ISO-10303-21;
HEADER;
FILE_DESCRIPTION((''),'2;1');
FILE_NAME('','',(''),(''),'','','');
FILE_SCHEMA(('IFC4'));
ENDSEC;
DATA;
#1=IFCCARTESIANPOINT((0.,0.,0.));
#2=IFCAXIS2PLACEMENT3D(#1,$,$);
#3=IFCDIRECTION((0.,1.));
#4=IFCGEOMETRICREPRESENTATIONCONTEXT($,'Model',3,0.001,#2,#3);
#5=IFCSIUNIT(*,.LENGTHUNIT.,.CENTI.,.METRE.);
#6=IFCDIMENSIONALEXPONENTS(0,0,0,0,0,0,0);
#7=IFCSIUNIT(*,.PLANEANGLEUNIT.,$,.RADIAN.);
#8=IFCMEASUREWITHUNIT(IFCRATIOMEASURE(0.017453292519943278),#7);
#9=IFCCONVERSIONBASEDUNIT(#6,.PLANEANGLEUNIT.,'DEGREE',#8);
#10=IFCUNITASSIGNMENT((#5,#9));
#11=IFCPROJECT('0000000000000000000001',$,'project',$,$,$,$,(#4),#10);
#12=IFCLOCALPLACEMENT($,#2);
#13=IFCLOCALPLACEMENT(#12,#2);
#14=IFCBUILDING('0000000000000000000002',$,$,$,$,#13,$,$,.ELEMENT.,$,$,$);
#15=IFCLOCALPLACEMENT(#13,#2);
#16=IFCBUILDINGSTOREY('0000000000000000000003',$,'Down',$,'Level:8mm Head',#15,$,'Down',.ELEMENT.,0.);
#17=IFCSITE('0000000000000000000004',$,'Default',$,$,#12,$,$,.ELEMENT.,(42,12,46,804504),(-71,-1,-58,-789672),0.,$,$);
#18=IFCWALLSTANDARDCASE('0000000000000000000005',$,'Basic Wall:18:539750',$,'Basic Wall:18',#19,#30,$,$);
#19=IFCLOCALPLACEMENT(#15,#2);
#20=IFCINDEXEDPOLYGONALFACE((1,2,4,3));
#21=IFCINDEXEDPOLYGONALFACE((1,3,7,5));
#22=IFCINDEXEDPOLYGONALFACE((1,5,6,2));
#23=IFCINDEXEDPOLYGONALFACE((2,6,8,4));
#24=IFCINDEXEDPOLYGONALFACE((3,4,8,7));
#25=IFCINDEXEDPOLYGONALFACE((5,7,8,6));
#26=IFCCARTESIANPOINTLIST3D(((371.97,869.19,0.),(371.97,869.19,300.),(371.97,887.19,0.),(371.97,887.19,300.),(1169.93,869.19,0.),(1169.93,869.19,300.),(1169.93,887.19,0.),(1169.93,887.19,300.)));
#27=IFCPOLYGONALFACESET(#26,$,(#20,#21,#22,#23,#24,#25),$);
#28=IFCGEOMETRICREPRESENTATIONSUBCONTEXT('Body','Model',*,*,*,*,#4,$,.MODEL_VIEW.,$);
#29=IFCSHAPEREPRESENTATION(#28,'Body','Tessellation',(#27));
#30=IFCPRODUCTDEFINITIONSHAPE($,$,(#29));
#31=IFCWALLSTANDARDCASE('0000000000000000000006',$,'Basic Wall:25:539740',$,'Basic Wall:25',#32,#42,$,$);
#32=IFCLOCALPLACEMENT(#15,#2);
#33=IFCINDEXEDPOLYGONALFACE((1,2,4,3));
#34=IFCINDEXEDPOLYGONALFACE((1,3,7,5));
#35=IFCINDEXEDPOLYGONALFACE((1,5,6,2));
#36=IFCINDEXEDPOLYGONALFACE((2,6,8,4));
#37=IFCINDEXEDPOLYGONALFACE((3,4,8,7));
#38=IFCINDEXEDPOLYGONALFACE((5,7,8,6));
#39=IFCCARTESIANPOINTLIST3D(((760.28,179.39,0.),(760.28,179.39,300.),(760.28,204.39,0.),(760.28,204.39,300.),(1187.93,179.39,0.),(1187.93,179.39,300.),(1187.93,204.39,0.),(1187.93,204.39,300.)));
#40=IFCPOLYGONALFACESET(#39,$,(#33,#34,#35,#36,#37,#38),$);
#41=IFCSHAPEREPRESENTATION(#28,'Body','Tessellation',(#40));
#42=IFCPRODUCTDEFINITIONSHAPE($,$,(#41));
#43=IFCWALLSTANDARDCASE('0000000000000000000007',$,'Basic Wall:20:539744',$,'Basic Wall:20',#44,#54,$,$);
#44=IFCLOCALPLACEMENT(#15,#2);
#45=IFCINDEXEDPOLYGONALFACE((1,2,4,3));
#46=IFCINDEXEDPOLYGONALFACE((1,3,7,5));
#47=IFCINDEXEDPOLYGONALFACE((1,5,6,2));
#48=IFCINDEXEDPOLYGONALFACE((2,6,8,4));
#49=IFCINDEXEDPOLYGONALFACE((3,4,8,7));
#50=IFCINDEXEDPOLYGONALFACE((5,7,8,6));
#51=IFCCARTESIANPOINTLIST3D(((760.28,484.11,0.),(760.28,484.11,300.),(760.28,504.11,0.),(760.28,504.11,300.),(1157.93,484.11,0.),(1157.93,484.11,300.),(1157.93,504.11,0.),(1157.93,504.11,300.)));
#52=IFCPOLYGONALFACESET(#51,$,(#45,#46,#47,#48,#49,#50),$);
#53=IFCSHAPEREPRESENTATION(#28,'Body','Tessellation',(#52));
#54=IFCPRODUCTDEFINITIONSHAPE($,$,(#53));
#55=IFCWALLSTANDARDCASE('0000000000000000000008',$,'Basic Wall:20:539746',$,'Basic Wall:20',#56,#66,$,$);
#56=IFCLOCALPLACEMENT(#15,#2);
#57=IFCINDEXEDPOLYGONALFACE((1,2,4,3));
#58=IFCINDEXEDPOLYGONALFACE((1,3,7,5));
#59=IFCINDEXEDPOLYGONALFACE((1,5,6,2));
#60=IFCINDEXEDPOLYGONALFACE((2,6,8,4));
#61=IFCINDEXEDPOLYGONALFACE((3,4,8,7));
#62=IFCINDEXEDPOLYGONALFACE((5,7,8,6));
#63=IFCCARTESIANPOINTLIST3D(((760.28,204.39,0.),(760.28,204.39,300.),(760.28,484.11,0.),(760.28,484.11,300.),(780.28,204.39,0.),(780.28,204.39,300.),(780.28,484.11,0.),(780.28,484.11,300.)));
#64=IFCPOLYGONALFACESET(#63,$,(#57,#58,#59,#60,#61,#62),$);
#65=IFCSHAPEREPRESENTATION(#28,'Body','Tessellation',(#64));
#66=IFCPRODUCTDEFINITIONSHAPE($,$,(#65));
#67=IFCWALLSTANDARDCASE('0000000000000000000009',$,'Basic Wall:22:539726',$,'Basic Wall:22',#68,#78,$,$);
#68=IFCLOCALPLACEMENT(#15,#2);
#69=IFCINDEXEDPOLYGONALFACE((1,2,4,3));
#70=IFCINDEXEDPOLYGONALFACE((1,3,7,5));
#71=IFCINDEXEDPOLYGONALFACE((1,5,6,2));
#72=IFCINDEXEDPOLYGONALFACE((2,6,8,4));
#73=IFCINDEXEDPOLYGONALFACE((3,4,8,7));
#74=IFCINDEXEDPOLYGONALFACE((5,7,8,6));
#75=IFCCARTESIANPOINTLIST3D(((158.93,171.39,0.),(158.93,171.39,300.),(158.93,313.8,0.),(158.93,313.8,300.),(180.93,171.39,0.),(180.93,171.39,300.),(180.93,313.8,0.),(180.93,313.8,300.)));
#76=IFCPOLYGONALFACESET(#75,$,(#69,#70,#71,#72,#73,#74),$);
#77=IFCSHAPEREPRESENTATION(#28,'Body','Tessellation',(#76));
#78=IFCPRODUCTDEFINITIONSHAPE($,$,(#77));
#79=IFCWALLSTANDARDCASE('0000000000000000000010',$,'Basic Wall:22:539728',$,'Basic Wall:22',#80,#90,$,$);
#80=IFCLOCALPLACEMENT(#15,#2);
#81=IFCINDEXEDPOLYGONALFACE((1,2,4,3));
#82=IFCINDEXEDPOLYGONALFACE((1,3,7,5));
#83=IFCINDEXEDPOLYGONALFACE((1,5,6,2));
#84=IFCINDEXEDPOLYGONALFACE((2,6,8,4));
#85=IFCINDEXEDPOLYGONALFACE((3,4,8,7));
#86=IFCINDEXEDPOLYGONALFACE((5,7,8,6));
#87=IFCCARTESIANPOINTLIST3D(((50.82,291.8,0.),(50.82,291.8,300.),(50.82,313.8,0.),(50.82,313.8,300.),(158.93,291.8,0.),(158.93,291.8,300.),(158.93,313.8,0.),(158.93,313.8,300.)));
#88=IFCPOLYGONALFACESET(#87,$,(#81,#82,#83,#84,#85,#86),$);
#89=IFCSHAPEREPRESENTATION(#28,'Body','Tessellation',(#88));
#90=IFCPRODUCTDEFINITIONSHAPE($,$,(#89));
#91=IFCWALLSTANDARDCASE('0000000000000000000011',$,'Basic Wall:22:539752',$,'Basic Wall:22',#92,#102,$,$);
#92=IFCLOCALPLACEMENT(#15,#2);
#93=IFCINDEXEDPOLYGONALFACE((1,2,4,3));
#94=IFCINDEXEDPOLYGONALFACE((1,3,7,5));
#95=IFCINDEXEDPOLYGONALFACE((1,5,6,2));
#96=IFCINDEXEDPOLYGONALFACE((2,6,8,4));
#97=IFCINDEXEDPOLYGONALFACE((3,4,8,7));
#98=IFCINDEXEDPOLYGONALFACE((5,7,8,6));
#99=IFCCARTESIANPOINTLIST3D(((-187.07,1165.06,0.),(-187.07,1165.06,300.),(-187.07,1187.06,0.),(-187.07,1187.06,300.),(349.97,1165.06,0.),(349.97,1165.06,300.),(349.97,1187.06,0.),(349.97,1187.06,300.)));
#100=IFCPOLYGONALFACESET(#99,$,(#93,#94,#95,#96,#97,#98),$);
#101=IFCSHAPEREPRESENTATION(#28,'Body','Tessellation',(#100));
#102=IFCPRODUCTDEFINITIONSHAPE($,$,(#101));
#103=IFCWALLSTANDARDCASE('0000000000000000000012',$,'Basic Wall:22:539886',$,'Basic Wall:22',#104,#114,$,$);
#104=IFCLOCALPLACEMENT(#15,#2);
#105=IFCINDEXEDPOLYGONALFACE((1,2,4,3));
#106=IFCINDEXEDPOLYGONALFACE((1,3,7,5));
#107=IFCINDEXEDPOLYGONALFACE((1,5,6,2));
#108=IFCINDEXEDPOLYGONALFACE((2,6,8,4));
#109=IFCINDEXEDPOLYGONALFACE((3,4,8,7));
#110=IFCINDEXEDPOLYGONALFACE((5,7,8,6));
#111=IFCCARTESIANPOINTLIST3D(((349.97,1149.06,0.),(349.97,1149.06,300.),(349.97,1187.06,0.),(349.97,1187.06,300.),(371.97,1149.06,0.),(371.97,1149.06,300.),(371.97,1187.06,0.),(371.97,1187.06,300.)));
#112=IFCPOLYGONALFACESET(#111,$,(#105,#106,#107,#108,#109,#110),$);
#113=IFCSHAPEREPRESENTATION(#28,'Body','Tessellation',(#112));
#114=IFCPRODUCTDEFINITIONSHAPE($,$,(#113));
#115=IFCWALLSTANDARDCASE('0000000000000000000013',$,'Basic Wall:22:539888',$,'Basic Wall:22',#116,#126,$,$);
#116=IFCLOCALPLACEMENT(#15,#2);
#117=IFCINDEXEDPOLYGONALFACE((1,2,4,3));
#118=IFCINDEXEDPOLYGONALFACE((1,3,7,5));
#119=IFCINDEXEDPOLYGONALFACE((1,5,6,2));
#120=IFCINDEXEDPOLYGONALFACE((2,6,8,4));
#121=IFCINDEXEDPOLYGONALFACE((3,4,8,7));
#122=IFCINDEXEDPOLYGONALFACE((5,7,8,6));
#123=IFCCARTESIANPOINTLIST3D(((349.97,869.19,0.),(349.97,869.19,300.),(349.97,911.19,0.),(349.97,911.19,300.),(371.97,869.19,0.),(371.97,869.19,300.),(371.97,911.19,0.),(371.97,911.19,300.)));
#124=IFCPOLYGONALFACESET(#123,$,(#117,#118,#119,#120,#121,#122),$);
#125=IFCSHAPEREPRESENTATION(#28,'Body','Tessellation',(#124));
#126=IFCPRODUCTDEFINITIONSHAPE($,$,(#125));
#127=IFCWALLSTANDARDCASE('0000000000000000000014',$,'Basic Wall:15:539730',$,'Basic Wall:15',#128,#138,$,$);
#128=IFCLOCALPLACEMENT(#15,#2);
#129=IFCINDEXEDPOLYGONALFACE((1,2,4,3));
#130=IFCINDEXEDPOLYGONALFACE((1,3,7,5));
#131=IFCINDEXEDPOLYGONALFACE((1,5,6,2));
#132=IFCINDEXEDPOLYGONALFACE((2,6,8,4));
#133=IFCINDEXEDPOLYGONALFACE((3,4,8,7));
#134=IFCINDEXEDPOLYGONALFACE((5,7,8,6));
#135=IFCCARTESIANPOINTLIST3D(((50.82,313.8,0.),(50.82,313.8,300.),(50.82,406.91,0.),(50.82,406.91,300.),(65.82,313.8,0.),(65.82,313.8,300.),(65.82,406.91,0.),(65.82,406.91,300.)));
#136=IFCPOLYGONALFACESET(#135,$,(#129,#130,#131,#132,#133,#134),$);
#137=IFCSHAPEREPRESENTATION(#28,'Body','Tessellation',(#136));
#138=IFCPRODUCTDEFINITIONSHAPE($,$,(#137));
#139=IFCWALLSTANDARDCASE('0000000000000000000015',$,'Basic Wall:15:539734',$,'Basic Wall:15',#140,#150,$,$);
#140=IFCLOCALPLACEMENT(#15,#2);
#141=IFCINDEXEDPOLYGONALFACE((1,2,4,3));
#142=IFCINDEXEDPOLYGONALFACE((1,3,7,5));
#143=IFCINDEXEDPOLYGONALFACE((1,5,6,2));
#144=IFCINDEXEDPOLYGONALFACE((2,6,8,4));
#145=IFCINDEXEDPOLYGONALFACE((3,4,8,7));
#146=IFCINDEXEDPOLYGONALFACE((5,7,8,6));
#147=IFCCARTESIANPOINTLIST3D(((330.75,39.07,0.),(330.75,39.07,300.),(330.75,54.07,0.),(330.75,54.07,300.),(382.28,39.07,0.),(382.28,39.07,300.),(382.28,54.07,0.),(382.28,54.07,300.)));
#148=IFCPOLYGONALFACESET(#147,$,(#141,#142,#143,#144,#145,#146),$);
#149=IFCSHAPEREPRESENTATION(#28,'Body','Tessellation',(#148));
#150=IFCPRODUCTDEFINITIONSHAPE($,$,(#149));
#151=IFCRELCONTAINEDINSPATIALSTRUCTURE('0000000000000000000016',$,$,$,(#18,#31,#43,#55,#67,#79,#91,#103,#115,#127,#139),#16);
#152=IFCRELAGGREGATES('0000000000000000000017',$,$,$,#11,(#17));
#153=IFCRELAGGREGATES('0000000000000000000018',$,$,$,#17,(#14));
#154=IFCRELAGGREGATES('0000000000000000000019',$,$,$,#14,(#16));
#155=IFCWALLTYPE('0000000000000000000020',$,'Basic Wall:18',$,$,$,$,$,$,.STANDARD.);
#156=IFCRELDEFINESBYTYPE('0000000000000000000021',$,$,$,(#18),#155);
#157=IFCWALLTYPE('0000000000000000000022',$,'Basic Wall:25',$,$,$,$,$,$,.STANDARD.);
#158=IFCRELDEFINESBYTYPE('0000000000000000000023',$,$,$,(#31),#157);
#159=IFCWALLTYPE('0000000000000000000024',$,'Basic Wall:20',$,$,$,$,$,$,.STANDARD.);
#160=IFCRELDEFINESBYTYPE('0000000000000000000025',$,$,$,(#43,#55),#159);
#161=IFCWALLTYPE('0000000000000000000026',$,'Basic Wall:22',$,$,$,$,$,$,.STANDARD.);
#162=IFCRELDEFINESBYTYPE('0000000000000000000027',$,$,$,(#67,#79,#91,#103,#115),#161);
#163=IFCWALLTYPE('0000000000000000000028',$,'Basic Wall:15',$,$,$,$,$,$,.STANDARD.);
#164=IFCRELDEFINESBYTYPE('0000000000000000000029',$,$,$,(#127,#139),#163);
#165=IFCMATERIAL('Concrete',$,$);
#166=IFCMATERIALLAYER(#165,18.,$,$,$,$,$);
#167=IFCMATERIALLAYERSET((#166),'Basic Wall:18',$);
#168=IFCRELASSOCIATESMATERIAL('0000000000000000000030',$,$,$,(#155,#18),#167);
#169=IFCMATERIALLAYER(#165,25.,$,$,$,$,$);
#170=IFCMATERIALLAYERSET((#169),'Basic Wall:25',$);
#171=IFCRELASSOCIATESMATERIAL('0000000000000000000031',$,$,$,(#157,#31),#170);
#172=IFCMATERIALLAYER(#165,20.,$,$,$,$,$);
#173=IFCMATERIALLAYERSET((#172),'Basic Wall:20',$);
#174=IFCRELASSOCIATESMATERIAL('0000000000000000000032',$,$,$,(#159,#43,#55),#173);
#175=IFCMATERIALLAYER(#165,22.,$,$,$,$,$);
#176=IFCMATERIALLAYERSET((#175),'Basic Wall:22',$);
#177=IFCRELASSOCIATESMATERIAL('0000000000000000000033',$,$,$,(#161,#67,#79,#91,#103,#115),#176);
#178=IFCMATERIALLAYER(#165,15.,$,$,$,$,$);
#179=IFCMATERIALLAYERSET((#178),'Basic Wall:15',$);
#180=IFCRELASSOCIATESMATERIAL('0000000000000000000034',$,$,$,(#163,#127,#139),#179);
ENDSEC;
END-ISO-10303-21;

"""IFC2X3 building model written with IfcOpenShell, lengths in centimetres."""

from ifc_helpers import new_model, entity, si_unit, converted_unit, direction, frame, frame_2d, origin, place, context, subcontext, project, spatial, rectangle, extrude, material, layer, layer_set, layer_usage, type_object, element, save


model = new_model("IFC2X3")

# Units and contexts
model_context = context("Model", 3, precision=0.001, world=origin(), true_north=direction((0.0, 1.0)))
body_context = subcontext(model_context, "Body", "Model", "MODEL_VIEW")
ifc_project = project(units=[si_unit("LENGTHUNIT", "METRE", prefix="CENTI"), converted_unit("PLANEANGLEUNIT", "DEGREE", entity("IfcRatioMeasure", 0.017453292519943278), si_unit("PLANEANGLEUNIT", "RADIAN"), dimensions=[0, 0, 0, 0, 0, 0, 0])], contexts=[model_context])

# Site, building, storey
site_placement = place(None, origin())
site = spatial("IfcSite", under=ifc_project, at=site_placement, Name="Default", CompositionType="ELEMENT", RefLatitude=(42, 12, 46, 804504), RefLongitude=(-71, -1, -58, -789672), RefElevation=0.0)
building_placement = place(site_placement, origin())
building = spatial("IfcBuilding", under=site, at=building_placement, CompositionType="ELEMENT")
storey_placement = place(building_placement, origin())
storey = spatial("IfcBuildingStorey", under=building, at=storey_placement, Name="Down", ObjectType="Level:8mm Head", LongName="Down", CompositionType="ELEMENT", Elevation=0.0)

# Shared definitions
ifc_material = material(Name="Concrete")

# Walls
ifc_layer_1 = layer(ifc_material, 18.0)
ifc_layer_set_1 = layer_set([ifc_layer_1], Name="Basic Wall:18")
wall_type_1 = type_object("IfcWallType", Name="Basic Wall:18", PredefinedType="STANDARD", material=ifc_layer_set_1)
ifc_layer_usage_1 = layer_usage(ifc_layer_set_1, "AXIS2", "NEGATIVE", 9.0)
wall_1_placement = place(storey_placement, frame((1169.93, 878.19, 0.0), z_axis=(0.0, 0.0, 1.0), x_axis=(-1.0, 0.0, 0.0)))
element("IfcWallStandardCase", 1, at=wall_1_placement, inside=storey, type_object=wall_type_1, material=ifc_layer_usage_1, Name="Basic Wall:18:539750", ObjectType="Basic Wall:18", context=body_context, shape_type="SweptSolid", body=[
    extrude(rectangle(XDim=797.96, YDim=18.0, at=frame_2d((398.98, 0.0), x_axis=(-1.0, 0.0))), origin(), (0.0, 0.0, 1.0), 300.0),
])
ifc_layer_2 = layer(ifc_material, 25.0)
ifc_layer_set_2 = layer_set([ifc_layer_2], Name="Basic Wall:25")
ifc_layer_usage_2 = layer_usage(ifc_layer_set_2, "AXIS2", "POSITIVE", -12.5)
wall_type_2 = type_object("IfcWallType", Name="Basic Wall:25", PredefinedType="STANDARD", material=ifc_layer_set_2)
wall_2_placement = place(storey_placement, frame((1187.93, 191.89, 0.0), z_axis=(0.0, 0.0, 1.0), x_axis=(-1.0, 0.0, 0.0)))
element("IfcWallStandardCase", 2, at=wall_2_placement, inside=storey, type_object=wall_type_2, material=ifc_layer_usage_2, Name="Basic Wall:25:539740", ObjectType="Basic Wall:25", context=body_context, shape_type="SweptSolid", body=[
    extrude(rectangle(XDim=427.65, YDim=25.0, at=frame_2d((213.82, 0.0), x_axis=(-1.0, 0.0))), origin(), (0.0, 0.0, 1.0), 300.0),
])
ifc_layer_3 = layer(ifc_material, 20.0)
ifc_layer_set_3 = layer_set([ifc_layer_3], Name="Basic Wall:20")
ifc_layer_usage_3 = layer_usage(ifc_layer_set_3, "AXIS2", "POSITIVE", -10.0)
wall_type_3 = type_object("IfcWallType", Name="Basic Wall:20", PredefinedType="STANDARD", material=ifc_layer_set_3)
wall_3_placement = place(storey_placement, frame((1157.93, 494.11, 0.0), z_axis=(0.0, 0.0, 1.0), x_axis=(-1.0, 0.0, 0.0)))
element("IfcWallStandardCase", 3, at=wall_3_placement, inside=storey, type_object=wall_type_3, material=ifc_layer_usage_3, Name="Basic Wall:20:539744", ObjectType="Basic Wall:20", context=body_context, shape_type="SweptSolid", body=[
    extrude(rectangle(XDim=397.65, YDim=20.0, at=frame_2d((198.82, 0.0), x_axis=(-1.0, 0.0))), origin(), (0.0, 0.0, 1.0), 300.0),
])
ifc_layer_usage_4 = layer_usage(ifc_layer_set_3, "AXIS2", "POSITIVE", -10.0)
wall_4_placement = place(storey_placement, frame((770.28, 204.39, 0.0), z_axis=(0.0, 0.0, 1.0), x_axis=(0.0, 1.0, 0.0)))
element("IfcWallStandardCase", 4, at=wall_4_placement, inside=storey, type_object=wall_type_3, material=ifc_layer_usage_4, Name="Basic Wall:20:539746", ObjectType="Basic Wall:20", context=body_context, shape_type="SweptSolid", body=[
    extrude(rectangle(XDim=279.72, YDim=20.0, at=frame_2d((139.86, 0.0), x_axis=(-1.0, 0.0))), origin(), (0.0, 0.0, 1.0), 300.0),
])
ifc_layer_4 = layer(ifc_material, 22.0)
ifc_layer_set_4 = layer_set([ifc_layer_4], Name="Basic Wall:22")
ifc_layer_usage_5 = layer_usage(ifc_layer_set_4, "AXIS2", "POSITIVE", -11.0)
wall_type_4 = type_object("IfcWallType", Name="Basic Wall:22", PredefinedType="STANDARD", material=ifc_layer_set_4)
wall_5_placement = place(storey_placement, frame((169.93, 313.8, 0.0), z_axis=(0.0, 0.0, 1.0), x_axis=(0.0, -1.0, 0.0)))
element("IfcWallStandardCase", 5, at=wall_5_placement, inside=storey, type_object=wall_type_4, material=ifc_layer_usage_5, Name="Basic Wall:22:539726", ObjectType="Basic Wall:22", context=body_context, shape_type="SweptSolid", body=[
    extrude(rectangle(XDim=142.4, YDim=22.0, at=frame_2d((71.2, 0.0), x_axis=(-1.0, 0.0))), origin(), (0.0, 0.0, 1.0), 300.0),
])
ifc_layer_usage_6 = layer_usage(ifc_layer_set_4, "AXIS2", "NEGATIVE", 11.0)
wall_6_placement = place(storey_placement, frame((158.93, 302.8, 0.0), z_axis=(0.0, 0.0, 1.0), x_axis=(-1.0, 0.0, 0.0)))
element("IfcWallStandardCase", 6, at=wall_6_placement, inside=storey, type_object=wall_type_4, material=ifc_layer_usage_6, Name="Basic Wall:22:539728", ObjectType="Basic Wall:22", context=body_context, shape_type="SweptSolid", body=[
    extrude(rectangle(XDim=108.11, YDim=22.0, at=frame_2d((54.06, 0.0), x_axis=(-1.0, 0.0))), origin(), (0.0, 0.0, 1.0), 300.0),
])
ifc_layer_usage_7 = layer_usage(ifc_layer_set_4, "AXIS2", "NEGATIVE", 11.0)
wall_7_placement = place(storey_placement, frame((349.97, 1176.06, 0.0), z_axis=(0.0, 0.0, 1.0), x_axis=(-1.0, 0.0, 0.0)))
element("IfcWallStandardCase", 7, at=wall_7_placement, inside=storey, type_object=wall_type_4, material=ifc_layer_usage_7, Name="Basic Wall:22:539752", ObjectType="Basic Wall:22", context=body_context, shape_type="SweptSolid", body=[
    extrude(rectangle(XDim=537.04, YDim=22.0, at=frame_2d((268.52, 0.0), x_axis=(-1.0, 0.0))), origin(), (0.0, 0.0, 1.0), 300.0),
])
ifc_layer_usage_8 = layer_usage(ifc_layer_set_4, "AXIS2", "POSITIVE", -11.0)
wall_8_placement = place(storey_placement, frame((360.97, 1187.06, 0.0), z_axis=(0.0, 0.0, 1.0), x_axis=(0.0, -1.0, 0.0)))
element("IfcWallStandardCase", 8, at=wall_8_placement, inside=storey, type_object=wall_type_4, material=ifc_layer_usage_8, Name="Basic Wall:22:539886", ObjectType="Basic Wall:22", context=body_context, shape_type="SweptSolid", body=[
    extrude(rectangle(XDim=38.0, YDim=22.0, at=frame_2d((19.0, 0.0), x_axis=(-1.0, 0.0))), origin(), (0.0, 0.0, 1.0), 300.0),
])
ifc_layer_usage_9 = layer_usage(ifc_layer_set_4, "AXIS2", "POSITIVE", -11.0)
wall_9_placement = place(storey_placement, frame((360.97, 869.19, 0.0), z_axis=(0.0, 0.0, 1.0), x_axis=(0.0, 1.0, 0.0)))
element("IfcWallStandardCase", 9, at=wall_9_placement, inside=storey, type_object=wall_type_4, material=ifc_layer_usage_9, Name="Basic Wall:22:539888", ObjectType="Basic Wall:22", context=body_context, shape_type="SweptSolid", body=[
    extrude(rectangle(XDim=42.0, YDim=22.0, at=frame_2d((21.0, 0.0), x_axis=(-1.0, 0.0))), origin(), (0.0, 0.0, 1.0), 300.0),
])
ifc_layer_5 = layer(ifc_material, 15.0)
ifc_layer_set_5 = layer_set([ifc_layer_5], Name="Basic Wall:15")
ifc_layer_usage_10 = layer_usage(ifc_layer_set_5, "AXIS2", "NEGATIVE", 7.5)
wall_type_5 = type_object("IfcWallType", Name="Basic Wall:15", PredefinedType="STANDARD", material=ifc_layer_set_5)
wall_10_placement = place(storey_placement, frame((58.32, 406.91, 0.0), z_axis=(0.0, 0.0, 1.0), x_axis=(0.0, -1.0, 0.0)))
element("IfcWallStandardCase", 10, at=wall_10_placement, inside=storey, type_object=wall_type_5, material=ifc_layer_usage_10, Name="Basic Wall:15:539730", ObjectType="Basic Wall:15", context=body_context, shape_type="SweptSolid", body=[
    extrude(rectangle(XDim=93.11, YDim=15.0, at=frame_2d((46.56, 0.0), x_axis=(-1.0, 0.0))), origin(), (0.0, 0.0, 1.0), 300.0),
])
ifc_layer_usage_11 = layer_usage(ifc_layer_set_5, "AXIS2", "NEGATIVE", 7.5)
wall_11_placement = place(storey_placement, frame((330.75, 46.57, 0.0)))
element("IfcWallStandardCase", 11, at=wall_11_placement, inside=storey, type_object=wall_type_5, material=ifc_layer_usage_11, Name="Basic Wall:15:539734", ObjectType="Basic Wall:15", context=body_context, shape_type="SweptSolid", body=[
    extrude(rectangle(XDim=51.54, YDim=15.0, at=frame_2d((25.77, 0.0), x_axis=(-1.0, 0.0))), origin(), (0.0, 0.0, 1.0), 300.0),
])

save(model, "model.ifc")
